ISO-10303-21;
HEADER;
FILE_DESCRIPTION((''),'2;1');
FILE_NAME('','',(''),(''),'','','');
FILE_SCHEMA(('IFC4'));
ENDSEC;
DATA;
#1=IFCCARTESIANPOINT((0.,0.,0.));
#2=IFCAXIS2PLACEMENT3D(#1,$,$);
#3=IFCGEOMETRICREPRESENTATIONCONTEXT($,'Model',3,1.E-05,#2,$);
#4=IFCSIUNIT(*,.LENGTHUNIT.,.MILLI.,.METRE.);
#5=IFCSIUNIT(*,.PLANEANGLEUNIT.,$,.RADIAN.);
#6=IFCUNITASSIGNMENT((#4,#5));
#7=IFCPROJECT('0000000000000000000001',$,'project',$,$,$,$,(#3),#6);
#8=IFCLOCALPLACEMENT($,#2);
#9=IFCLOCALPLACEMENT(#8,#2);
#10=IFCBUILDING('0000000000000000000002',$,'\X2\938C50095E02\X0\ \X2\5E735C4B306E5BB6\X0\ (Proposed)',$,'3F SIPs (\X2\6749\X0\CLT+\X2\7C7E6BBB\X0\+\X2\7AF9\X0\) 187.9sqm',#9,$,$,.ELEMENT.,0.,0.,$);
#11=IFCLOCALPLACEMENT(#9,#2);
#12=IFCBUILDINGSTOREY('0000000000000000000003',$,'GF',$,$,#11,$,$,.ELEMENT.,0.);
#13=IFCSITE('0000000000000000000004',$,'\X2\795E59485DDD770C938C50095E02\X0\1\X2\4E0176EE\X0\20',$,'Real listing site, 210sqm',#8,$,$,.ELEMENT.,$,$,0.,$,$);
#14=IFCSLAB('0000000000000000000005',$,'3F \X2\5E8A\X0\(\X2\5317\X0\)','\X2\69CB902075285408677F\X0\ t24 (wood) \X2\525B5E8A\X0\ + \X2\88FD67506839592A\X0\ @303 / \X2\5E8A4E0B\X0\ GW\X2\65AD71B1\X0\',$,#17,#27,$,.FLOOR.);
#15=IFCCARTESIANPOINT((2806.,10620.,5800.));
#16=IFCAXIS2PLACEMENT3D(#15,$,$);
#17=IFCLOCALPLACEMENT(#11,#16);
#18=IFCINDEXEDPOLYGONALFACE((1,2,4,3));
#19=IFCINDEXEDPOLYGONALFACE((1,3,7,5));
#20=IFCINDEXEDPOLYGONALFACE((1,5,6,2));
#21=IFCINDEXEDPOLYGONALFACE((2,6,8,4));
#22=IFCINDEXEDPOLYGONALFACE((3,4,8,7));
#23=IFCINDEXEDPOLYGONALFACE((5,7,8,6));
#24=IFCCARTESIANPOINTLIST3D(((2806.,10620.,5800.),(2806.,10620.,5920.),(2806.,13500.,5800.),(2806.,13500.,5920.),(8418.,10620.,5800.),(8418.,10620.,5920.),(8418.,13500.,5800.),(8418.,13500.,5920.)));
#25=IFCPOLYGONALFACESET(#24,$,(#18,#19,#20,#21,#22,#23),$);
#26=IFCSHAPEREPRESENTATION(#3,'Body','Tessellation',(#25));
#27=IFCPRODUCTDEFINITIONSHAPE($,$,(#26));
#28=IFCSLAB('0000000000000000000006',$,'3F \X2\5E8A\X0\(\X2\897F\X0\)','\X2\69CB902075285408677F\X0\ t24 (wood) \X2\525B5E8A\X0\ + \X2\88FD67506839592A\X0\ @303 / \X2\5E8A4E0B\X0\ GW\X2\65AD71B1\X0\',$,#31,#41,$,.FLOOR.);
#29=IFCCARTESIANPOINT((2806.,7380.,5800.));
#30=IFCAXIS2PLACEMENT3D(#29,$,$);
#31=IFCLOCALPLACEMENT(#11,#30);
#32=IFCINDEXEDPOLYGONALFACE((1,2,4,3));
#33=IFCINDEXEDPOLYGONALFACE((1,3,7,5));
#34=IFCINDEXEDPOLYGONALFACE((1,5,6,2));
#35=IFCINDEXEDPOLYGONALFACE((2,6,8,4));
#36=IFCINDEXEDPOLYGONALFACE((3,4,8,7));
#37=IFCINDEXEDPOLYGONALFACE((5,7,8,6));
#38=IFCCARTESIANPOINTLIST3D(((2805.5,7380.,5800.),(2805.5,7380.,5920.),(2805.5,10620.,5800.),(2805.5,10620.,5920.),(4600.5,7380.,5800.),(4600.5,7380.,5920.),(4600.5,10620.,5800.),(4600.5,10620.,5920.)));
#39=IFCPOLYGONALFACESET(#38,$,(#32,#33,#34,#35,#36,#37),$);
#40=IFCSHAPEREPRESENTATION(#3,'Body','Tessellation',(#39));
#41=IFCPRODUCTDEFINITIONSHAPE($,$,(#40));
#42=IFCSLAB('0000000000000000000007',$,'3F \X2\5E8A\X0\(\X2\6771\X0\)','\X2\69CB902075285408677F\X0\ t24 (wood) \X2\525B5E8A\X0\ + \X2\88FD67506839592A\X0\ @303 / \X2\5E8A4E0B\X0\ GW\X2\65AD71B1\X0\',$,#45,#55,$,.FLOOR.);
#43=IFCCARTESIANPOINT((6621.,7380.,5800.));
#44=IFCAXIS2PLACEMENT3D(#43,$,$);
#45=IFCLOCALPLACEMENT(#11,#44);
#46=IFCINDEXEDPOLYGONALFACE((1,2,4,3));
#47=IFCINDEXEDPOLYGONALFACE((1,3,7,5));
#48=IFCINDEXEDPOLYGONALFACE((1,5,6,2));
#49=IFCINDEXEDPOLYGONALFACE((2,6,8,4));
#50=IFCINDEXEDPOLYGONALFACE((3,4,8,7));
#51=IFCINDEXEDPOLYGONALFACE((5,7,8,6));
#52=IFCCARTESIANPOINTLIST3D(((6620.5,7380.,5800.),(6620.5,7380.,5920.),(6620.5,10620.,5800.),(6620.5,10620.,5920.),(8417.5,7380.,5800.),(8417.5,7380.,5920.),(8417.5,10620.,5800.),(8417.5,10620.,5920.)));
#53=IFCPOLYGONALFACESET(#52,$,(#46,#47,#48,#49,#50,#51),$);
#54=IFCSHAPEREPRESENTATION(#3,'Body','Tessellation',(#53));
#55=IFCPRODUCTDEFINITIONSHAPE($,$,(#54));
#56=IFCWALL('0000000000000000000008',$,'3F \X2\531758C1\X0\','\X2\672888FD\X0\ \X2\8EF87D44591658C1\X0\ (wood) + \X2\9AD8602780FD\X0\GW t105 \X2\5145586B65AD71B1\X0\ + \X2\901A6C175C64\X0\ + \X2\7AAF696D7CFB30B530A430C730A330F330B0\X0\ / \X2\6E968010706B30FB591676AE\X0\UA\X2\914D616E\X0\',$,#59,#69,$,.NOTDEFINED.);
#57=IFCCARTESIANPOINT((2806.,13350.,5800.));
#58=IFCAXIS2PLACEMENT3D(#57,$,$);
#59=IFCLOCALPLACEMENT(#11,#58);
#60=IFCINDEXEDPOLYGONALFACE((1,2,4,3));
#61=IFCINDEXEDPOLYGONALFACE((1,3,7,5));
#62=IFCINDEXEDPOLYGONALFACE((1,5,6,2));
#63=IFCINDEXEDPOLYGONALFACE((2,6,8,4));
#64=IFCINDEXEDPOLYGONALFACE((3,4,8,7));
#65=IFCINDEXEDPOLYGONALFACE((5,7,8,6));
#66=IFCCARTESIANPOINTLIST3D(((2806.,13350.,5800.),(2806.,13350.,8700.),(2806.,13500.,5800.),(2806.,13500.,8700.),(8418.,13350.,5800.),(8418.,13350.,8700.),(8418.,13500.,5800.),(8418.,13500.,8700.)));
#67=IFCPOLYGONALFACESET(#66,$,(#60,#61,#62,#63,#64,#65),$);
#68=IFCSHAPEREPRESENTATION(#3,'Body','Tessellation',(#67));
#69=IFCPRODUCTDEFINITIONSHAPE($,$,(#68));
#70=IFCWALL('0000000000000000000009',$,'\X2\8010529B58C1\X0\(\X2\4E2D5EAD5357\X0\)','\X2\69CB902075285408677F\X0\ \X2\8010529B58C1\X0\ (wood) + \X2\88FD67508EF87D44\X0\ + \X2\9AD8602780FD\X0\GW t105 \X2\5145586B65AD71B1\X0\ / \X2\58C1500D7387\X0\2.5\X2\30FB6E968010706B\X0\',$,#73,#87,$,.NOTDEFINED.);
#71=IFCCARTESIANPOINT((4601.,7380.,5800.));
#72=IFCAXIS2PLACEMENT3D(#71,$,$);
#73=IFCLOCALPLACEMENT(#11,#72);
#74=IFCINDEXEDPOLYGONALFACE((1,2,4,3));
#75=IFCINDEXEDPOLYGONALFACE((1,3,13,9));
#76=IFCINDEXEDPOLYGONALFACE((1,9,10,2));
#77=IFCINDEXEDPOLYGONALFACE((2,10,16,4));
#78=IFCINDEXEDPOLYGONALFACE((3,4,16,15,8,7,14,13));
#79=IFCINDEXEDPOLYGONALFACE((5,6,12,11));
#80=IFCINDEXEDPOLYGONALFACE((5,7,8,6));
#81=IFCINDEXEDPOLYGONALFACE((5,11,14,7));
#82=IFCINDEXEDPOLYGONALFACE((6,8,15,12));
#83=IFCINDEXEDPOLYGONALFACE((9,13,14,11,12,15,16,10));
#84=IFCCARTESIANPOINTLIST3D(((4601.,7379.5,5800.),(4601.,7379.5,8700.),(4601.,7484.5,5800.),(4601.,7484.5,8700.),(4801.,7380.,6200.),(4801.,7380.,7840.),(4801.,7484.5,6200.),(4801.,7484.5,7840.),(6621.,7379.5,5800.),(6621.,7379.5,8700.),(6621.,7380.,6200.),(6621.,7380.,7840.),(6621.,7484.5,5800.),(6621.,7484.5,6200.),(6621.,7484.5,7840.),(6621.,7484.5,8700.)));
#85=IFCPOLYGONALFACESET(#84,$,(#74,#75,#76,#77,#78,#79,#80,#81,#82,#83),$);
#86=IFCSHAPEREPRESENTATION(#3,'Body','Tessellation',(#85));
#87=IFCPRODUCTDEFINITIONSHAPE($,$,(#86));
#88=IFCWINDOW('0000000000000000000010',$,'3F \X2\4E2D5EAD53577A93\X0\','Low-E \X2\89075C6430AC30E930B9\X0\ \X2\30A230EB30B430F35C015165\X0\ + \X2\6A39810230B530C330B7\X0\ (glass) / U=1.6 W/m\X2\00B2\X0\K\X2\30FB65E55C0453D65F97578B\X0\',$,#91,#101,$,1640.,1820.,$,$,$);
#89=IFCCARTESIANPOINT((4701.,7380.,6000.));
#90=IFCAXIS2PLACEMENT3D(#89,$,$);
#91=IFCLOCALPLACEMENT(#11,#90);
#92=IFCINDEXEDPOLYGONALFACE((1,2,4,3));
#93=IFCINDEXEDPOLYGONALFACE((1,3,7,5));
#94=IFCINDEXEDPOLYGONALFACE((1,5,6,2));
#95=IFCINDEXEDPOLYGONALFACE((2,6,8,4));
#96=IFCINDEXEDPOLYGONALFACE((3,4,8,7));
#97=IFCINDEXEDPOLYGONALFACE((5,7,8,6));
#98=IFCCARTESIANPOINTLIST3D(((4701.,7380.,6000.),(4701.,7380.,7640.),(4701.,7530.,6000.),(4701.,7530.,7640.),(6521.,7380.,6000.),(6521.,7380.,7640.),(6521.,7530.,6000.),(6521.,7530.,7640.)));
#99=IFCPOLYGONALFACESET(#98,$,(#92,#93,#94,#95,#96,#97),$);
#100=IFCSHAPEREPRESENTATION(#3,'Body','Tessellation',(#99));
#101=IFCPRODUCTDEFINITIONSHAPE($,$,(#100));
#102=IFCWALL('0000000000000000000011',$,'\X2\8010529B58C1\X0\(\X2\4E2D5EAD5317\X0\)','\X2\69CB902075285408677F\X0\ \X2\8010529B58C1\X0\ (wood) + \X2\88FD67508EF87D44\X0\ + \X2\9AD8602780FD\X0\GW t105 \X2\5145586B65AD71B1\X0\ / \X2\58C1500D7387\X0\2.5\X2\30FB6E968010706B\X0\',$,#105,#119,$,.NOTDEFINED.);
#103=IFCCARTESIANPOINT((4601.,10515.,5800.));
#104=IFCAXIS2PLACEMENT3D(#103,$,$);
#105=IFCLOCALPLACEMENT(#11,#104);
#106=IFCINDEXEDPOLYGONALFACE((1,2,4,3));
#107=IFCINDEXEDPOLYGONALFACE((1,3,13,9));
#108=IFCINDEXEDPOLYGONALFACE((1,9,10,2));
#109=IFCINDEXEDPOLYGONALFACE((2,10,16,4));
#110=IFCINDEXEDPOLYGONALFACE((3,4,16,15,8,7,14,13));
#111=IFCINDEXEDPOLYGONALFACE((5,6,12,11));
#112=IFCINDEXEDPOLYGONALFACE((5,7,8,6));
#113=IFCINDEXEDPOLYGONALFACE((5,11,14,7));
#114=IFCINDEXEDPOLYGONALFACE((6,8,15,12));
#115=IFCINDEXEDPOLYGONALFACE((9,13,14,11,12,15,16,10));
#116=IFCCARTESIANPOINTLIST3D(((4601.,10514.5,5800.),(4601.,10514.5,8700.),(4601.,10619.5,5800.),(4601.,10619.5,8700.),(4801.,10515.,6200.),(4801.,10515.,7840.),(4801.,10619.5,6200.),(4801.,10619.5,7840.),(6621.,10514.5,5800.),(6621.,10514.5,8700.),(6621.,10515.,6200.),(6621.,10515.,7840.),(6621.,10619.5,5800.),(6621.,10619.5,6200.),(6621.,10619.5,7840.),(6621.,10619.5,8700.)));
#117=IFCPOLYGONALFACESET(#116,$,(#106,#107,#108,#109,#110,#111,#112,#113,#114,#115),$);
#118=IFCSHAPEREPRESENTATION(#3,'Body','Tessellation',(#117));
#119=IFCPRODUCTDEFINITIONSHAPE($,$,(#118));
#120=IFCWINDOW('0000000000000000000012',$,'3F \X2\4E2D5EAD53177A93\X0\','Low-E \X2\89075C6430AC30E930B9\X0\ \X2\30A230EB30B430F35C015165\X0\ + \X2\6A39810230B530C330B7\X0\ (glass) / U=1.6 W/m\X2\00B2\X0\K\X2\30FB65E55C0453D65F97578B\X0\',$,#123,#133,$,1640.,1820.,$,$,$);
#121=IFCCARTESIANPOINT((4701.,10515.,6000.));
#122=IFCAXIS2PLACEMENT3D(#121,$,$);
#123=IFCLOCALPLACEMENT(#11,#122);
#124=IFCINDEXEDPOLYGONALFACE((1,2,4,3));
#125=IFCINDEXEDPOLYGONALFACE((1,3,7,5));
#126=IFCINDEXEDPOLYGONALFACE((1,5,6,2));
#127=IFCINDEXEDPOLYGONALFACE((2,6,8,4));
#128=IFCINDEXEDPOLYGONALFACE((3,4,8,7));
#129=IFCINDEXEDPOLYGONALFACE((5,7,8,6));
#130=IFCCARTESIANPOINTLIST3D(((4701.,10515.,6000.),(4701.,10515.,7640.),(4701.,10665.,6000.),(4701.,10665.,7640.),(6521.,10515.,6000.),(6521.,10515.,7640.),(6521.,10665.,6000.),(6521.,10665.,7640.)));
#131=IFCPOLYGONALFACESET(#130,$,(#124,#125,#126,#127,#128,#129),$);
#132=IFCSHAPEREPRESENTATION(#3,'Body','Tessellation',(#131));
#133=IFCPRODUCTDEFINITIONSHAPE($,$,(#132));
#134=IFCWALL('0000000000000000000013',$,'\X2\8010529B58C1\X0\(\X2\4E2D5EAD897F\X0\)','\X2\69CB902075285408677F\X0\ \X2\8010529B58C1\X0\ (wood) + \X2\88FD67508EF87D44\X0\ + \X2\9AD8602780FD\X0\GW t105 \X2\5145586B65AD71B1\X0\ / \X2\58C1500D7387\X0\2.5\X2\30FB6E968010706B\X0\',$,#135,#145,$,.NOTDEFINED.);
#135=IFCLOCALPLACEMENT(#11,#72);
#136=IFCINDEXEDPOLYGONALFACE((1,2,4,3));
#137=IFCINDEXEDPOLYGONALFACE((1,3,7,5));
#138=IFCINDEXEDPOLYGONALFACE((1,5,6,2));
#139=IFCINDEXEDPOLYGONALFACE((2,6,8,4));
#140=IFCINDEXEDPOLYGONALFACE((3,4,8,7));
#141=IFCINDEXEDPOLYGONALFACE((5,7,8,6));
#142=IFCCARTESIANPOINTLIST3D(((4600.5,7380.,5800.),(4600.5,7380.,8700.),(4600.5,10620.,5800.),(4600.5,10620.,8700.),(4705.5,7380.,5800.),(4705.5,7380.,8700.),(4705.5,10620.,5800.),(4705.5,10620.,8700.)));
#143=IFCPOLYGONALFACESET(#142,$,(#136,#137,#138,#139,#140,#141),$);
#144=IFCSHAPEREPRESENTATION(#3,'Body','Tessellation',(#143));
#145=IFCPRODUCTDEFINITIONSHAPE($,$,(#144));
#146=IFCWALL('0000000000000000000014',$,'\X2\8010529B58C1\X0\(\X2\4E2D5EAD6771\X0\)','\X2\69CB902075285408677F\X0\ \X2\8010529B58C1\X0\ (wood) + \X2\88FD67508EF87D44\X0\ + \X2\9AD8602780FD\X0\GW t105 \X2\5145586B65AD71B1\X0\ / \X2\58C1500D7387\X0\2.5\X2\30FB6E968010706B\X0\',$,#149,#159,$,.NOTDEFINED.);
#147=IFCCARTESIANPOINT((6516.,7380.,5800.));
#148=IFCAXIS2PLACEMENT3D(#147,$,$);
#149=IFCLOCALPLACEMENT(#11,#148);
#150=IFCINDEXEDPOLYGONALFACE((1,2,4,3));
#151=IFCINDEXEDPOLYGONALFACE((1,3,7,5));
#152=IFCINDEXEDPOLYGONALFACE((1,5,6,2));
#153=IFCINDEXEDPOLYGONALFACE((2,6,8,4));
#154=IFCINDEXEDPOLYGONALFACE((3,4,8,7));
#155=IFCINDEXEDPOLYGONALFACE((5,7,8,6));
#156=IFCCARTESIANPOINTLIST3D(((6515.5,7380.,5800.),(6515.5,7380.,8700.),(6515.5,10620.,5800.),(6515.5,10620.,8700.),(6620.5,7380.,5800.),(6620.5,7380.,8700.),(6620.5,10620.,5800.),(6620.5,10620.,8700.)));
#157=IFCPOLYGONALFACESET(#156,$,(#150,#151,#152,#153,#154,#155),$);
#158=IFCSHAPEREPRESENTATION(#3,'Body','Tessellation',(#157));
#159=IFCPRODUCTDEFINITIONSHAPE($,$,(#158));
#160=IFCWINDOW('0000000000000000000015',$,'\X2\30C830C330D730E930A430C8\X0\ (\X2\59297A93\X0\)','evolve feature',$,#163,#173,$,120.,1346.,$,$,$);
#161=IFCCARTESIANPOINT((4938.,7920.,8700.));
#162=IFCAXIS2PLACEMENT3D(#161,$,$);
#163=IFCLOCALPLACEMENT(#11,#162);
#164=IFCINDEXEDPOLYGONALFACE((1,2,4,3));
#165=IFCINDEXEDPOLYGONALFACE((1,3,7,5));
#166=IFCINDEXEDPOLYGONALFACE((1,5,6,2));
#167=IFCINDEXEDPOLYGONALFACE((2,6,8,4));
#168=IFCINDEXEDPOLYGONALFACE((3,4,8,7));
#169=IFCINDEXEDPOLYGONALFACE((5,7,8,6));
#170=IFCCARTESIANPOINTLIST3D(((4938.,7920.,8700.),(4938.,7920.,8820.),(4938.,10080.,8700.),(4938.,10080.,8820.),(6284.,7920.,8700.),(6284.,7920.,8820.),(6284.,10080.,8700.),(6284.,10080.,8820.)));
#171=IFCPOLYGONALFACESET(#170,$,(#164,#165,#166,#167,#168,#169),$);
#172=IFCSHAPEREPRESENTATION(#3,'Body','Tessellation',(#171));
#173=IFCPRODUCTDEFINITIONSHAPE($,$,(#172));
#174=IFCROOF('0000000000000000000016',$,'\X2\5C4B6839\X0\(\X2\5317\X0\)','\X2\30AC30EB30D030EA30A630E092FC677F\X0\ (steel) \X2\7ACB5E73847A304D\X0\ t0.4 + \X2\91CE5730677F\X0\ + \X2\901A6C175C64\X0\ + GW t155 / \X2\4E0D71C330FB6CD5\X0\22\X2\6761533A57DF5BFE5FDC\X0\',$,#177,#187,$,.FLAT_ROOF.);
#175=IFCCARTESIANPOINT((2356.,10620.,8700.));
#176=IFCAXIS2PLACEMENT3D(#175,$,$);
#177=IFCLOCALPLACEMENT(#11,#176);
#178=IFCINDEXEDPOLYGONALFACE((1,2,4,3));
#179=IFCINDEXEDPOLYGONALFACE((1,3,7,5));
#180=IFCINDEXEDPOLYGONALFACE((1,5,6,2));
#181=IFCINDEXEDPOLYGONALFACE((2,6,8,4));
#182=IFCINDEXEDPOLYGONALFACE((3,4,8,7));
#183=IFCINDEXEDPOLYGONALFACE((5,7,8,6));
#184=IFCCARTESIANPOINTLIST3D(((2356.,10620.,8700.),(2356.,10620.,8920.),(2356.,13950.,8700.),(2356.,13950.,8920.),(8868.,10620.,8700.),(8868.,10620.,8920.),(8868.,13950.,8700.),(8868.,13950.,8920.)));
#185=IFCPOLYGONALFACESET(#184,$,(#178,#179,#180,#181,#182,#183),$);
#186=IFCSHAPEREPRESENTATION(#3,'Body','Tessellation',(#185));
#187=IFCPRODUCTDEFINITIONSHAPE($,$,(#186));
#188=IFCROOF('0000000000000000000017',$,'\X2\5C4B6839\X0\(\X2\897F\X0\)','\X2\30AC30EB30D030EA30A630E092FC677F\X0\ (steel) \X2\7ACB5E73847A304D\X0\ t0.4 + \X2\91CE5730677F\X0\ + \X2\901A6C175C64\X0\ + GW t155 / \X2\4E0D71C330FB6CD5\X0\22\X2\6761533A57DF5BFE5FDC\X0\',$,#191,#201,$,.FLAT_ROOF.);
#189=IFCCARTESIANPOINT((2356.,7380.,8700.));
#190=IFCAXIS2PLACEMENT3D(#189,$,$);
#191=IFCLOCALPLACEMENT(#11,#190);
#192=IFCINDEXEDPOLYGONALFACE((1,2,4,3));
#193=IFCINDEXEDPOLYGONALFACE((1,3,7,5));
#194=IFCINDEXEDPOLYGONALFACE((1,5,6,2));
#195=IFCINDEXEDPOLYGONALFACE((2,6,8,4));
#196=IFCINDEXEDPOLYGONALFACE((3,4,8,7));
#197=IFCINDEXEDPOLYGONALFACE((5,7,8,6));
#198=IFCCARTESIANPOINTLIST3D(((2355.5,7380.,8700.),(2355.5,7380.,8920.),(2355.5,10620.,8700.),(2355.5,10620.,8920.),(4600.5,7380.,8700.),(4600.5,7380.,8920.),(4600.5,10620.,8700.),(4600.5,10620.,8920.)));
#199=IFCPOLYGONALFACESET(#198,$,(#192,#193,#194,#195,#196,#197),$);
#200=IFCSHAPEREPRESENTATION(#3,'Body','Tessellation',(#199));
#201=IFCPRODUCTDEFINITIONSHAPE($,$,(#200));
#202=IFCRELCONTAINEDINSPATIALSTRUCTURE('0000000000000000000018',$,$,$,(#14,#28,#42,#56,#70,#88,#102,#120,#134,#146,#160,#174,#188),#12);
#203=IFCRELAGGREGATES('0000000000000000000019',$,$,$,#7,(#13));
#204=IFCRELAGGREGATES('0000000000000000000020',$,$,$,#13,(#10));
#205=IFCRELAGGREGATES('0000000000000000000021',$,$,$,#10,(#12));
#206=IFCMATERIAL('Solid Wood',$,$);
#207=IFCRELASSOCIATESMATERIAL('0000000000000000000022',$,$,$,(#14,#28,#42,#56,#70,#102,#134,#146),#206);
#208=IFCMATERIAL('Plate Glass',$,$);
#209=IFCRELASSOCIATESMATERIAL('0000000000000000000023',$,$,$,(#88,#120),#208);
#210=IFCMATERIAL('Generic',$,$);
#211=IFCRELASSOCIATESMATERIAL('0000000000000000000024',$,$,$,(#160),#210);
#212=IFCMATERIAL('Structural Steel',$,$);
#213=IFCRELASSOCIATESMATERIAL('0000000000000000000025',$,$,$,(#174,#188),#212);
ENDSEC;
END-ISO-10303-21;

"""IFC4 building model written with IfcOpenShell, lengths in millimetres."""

from ifc_helpers import new_model, si_unit, frame, frame_2d, origin, place, context, project, spatial, rectangle, extrude, material, element, fill, save


model = new_model("IFC4")

# Units and contexts
model_context = context("Model", 3, precision=1e-05, world=origin())
ifc_project = project(units=[si_unit("LENGTHUNIT", "METRE", prefix="MILLI"), si_unit("PLANEANGLEUNIT", "RADIAN")], contexts=[model_context])

# Site, building, storey
site_placement = place(None, origin())
site = spatial("IfcSite", under=ifc_project, at=site_placement, Name="神奈川県鎌倉市1丁目20", ObjectType="Real listing site, 210sqm", CompositionType="ELEMENT", RefElevation=0.0)
building_placement = place(site_placement, origin())
building = spatial("IfcBuilding", under=site, at=building_placement, Name="鎌倉市 平屋の家 (Proposed)", ObjectType="3F SIPs (杉CLT+籾殻+竹) 187.9sqm", CompositionType="ELEMENT", ElevationOfRefHeight=0.0, ElevationOfTerrain=0.0)
storey_placement = place(building_placement, origin())
storey = spatial("IfcBuildingStorey", under=building, at=storey_placement, Name="GF", CompositionType="ELEMENT", Elevation=0.0)

# Slabs
ifc_material_1 = material(Name="Solid Wood")
slab_1_placement = place(storey_placement, frame((2806.0, 10620.0, 5800.0)))
element("IfcSlab", 1, at=slab_1_placement, inside=storey, material=ifc_material_1, Name="3F 床(北)", Description="構造用合板 t24 (wood) 剛床 + 製材根太 @303 / 床下 GW断熱", PredefinedType="FLOOR", context=model_context, shape_type="SweptSolid", body=[
    extrude(rectangle(XDim=5612.0, YDim=2880.0, at=frame_2d((2806.0, 1440.0))), frame((2806.0, 10620.0, 5800.0)), (0.0, 0.0, 1.0), 120.0),
])
slab_2_placement = place(storey_placement, frame((2806.0, 7380.0, 5800.0)))
element("IfcSlab", 2, at=slab_2_placement, inside=storey, material=ifc_material_1, Name="3F 床(西)", Description="構造用合板 t24 (wood) 剛床 + 製材根太 @303 / 床下 GW断熱", PredefinedType="FLOOR", context=model_context, shape_type="SweptSolid", body=[
    extrude(rectangle(XDim=1795.0, YDim=3240.0, at=frame_2d((897.0, 1620.0))), frame((2806.0, 7380.0, 5800.0)), (0.0, 0.0, 1.0), 120.0),
])
slab_3_placement = place(storey_placement, frame((6621.0, 7380.0, 5800.0)))
element("IfcSlab", 3, at=slab_3_placement, inside=storey, material=ifc_material_1, Name="3F 床(東)", Description="構造用合板 t24 (wood) 剛床 + 製材根太 @303 / 床下 GW断熱", PredefinedType="FLOOR", context=model_context, shape_type="SweptSolid", body=[
    extrude(rectangle(XDim=1797.0, YDim=3240.0, at=frame_2d((898.0, 1620.0))), frame((6621.0, 7380.0, 5800.0)), (0.0, 0.0, 1.0), 120.0),
])

# Wall
wall_1_placement = place(storey_placement, frame((2806.0, 13350.0, 5800.0)))
element("IfcWall", 4, at=wall_1_placement, inside=storey, material=ifc_material_1, Name="3F 北壁", Description="木製 軸組外壁 (wood) + 高性能GW t105 充填断熱 + 通気層 + 窯業系サイディング / 準耐火・外皮UA配慮", PredefinedType="NOTDEFINED", context=model_context, shape_type="SweptSolid", body=[
    extrude(rectangle(XDim=5612.0, YDim=150.0, at=frame_2d((2806.0, 75.0))), frame((2806.0, 13350.0, 5800.0)), (0.0, 0.0, 1.0), 2900.0),
])

# Walls, openings, windows
wall_2_placement = place(storey_placement, frame((4601.0, 7380.0, 5800.0)))
wall_2 = element("IfcWall", 5, at=wall_2_placement, inside=storey, material=ifc_material_1, Name="耐力壁(中庭南)", Description="構造用合板 耐力壁 (wood) + 製材軸組 + 高性能GW t105 充填断熱 / 壁倍率2.5・準耐火", PredefinedType="NOTDEFINED", context=model_context, shape_type="SweptSolid", body=[
    extrude(rectangle(XDim=2020.0, YDim=105.0, at=frame_2d((1010.0, 52.0))), frame((4601.0, 7380.0, 5800.0)), (0.0, 0.0, 1.0), 2900.0),
])
opening_1_placement = place(storey_placement, frame((4701.0, 7380.0, 6000.0)))
opening_1 = element("IfcOpeningElement", 6, at=opening_1_placement, cuts=wall_2, PredefinedType="NOTDEFINED", context=model_context, shape_type="SweptSolid", body=[
    extrude(rectangle(XDim=1820.0, YDim=150.0, at=frame_2d((910.0, 75.0))), frame((4701.0, 7380.0, 6000.0)), (0.0, 0.0, 1.0), 1640.0),
])
ifc_material_2 = material(Name="Plate Glass")
window_1_placement = place(storey_placement, frame((4701.0, 7380.0, 6000.0)))
window_1 = element("IfcWindow", 7, at=window_1_placement, inside=storey, material=ifc_material_2, Name="3F 中庭南窓", Description="Low-E 複層ガラス アルゴン封入 + 樹脂サッシ (glass) / U=1.6 W/m²K・日射取得型", OverallHeight=1640.0, OverallWidth=1820.0, context=model_context, shape_type="SweptSolid", body=[
    extrude(rectangle(XDim=1820.0, YDim=150.0, at=frame_2d((910.0, 75.0))), frame((4701.0, 7380.0, 6000.0)), (0.0, 0.0, 1.0), 1640.0),
])
fill(opening_1, window_1)
wall_3_placement = place(storey_placement, frame((4601.0, 10515.0, 5800.0)))
wall_3 = element("IfcWall", 8, at=wall_3_placement, inside=storey, material=ifc_material_1, Name="耐力壁(中庭北)", Description="構造用合板 耐力壁 (wood) + 製材軸組 + 高性能GW t105 充填断熱 / 壁倍率2.5・準耐火", PredefinedType="NOTDEFINED", context=model_context, shape_type="SweptSolid", body=[
    extrude(rectangle(XDim=2020.0, YDim=105.0, at=frame_2d((1010.0, 52.0))), frame((4601.0, 10515.0, 5800.0)), (0.0, 0.0, 1.0), 2900.0),
])
opening_2_placement = place(storey_placement, frame((4701.0, 10515.0, 6000.0)))
opening_2 = element("IfcOpeningElement", 9, at=opening_2_placement, cuts=wall_3, PredefinedType="NOTDEFINED", context=model_context, shape_type="SweptSolid", body=[
    extrude(rectangle(XDim=1820.0, YDim=150.0, at=frame_2d((910.0, 75.0))), frame((4701.0, 10515.0, 6000.0)), (0.0, 0.0, 1.0), 1640.0),
])
window_2_placement = place(storey_placement, frame((4701.0, 10515.0, 6000.0)))
window_2 = element("IfcWindow", 10, at=window_2_placement, inside=storey, material=ifc_material_2, Name="3F 中庭北窓", Description="Low-E 複層ガラス アルゴン封入 + 樹脂サッシ (glass) / U=1.6 W/m²K・日射取得型", OverallHeight=1640.0, OverallWidth=1820.0, context=model_context, shape_type="SweptSolid", body=[
    extrude(rectangle(XDim=1820.0, YDim=150.0, at=frame_2d((910.0, 75.0))), frame((4701.0, 10515.0, 6000.0)), (0.0, 0.0, 1.0), 1640.0),
])
fill(opening_2, window_2)

# Walls
wall_4_placement = place(storey_placement, frame((4601.0, 7380.0, 5800.0)))
element("IfcWall", 11, at=wall_4_placement, inside=storey, material=ifc_material_1, Name="耐力壁(中庭西)", Description="構造用合板 耐力壁 (wood) + 製材軸組 + 高性能GW t105 充填断熱 / 壁倍率2.5・準耐火", PredefinedType="NOTDEFINED", context=model_context, shape_type="SweptSolid", body=[
    extrude(rectangle(XDim=105.0, YDim=3240.0, at=frame_2d((52.0, 1620.0))), frame((4601.0, 7380.0, 5800.0)), (0.0, 0.0, 1.0), 2900.0),
])
wall_5_placement = place(storey_placement, frame((6516.0, 7380.0, 5800.0)))
element("IfcWall", 12, at=wall_5_placement, inside=storey, material=ifc_material_1, Name="耐力壁(中庭東)", Description="構造用合板 耐力壁 (wood) + 製材軸組 + 高性能GW t105 充填断熱 / 壁倍率2.5・準耐火", PredefinedType="NOTDEFINED", context=model_context, shape_type="SweptSolid", body=[
    extrude(rectangle(XDim=105.0, YDim=3240.0, at=frame_2d((52.0, 1620.0))), frame((6516.0, 7380.0, 5800.0)), (0.0, 0.0, 1.0), 2900.0),
])

# Window
ifc_material_3 = material(Name="Generic")
window_3_placement = place(storey_placement, frame((4938.0, 7920.0, 8700.0)))
element("IfcWindow", 13, at=window_3_placement, inside=storey, material=ifc_material_3, Name="トップライト (天窓)", Description="evolve feature", OverallHeight=120.0, OverallWidth=1346.0, context=model_context, shape_type="SweptSolid", body=[
    extrude(rectangle(XDim=1346.0, YDim=2160.0, at=frame_2d((673.0, 1080.0))), frame((4938.0, 7920.0, 8700.0)), (0.0, 0.0, 1.0), 120.0),
])

# Roofs
ifc_material_4 = material(Name="Structural Steel")
for number, where, name in (
    (14, (2356.0, 10620.0, 8700.0), "屋根(北)"),
):
    element("IfcRoof", number, at=place(storey_placement, frame(where)), inside=storey, material=ifc_material_4, Name=name, Description="ガルバリウム鋼板 (steel) 立平葺き t0.4 + 野地板 + 通気層 + GW t155 / 不燃・法22条区域対応", PredefinedType="FLAT_ROOF", context=model_context, shape_type="SweptSolid", body=[
        extrude(rectangle(XDim=6512.0, YDim=3330.0, at=frame_2d((3256.0, 1665.0))), frame((2356.0, 10620.0, 8700.0)), (0.0, 0.0, 1.0), 220.0),
    ])
roof_1_placement = place(storey_placement, frame((2356.0, 7380.0, 8700.0)))
element("IfcRoof", 15, at=roof_1_placement, inside=storey, material=ifc_material_4, Name="屋根(西)", Description="ガルバリウム鋼板 (steel) 立平葺き t0.4 + 野地板 + 通気層 + GW t155 / 不燃・法22条区域対応", PredefinedType="FLAT_ROOF", context=model_context, shape_type="SweptSolid", body=[
    extrude(rectangle(XDim=2245.0, YDim=3240.0, at=frame_2d((1122.0, 1620.0))), frame((2356.0, 7380.0, 8700.0)), (0.0, 0.0, 1.0), 220.0),
])

save(model, "model.ifc")
